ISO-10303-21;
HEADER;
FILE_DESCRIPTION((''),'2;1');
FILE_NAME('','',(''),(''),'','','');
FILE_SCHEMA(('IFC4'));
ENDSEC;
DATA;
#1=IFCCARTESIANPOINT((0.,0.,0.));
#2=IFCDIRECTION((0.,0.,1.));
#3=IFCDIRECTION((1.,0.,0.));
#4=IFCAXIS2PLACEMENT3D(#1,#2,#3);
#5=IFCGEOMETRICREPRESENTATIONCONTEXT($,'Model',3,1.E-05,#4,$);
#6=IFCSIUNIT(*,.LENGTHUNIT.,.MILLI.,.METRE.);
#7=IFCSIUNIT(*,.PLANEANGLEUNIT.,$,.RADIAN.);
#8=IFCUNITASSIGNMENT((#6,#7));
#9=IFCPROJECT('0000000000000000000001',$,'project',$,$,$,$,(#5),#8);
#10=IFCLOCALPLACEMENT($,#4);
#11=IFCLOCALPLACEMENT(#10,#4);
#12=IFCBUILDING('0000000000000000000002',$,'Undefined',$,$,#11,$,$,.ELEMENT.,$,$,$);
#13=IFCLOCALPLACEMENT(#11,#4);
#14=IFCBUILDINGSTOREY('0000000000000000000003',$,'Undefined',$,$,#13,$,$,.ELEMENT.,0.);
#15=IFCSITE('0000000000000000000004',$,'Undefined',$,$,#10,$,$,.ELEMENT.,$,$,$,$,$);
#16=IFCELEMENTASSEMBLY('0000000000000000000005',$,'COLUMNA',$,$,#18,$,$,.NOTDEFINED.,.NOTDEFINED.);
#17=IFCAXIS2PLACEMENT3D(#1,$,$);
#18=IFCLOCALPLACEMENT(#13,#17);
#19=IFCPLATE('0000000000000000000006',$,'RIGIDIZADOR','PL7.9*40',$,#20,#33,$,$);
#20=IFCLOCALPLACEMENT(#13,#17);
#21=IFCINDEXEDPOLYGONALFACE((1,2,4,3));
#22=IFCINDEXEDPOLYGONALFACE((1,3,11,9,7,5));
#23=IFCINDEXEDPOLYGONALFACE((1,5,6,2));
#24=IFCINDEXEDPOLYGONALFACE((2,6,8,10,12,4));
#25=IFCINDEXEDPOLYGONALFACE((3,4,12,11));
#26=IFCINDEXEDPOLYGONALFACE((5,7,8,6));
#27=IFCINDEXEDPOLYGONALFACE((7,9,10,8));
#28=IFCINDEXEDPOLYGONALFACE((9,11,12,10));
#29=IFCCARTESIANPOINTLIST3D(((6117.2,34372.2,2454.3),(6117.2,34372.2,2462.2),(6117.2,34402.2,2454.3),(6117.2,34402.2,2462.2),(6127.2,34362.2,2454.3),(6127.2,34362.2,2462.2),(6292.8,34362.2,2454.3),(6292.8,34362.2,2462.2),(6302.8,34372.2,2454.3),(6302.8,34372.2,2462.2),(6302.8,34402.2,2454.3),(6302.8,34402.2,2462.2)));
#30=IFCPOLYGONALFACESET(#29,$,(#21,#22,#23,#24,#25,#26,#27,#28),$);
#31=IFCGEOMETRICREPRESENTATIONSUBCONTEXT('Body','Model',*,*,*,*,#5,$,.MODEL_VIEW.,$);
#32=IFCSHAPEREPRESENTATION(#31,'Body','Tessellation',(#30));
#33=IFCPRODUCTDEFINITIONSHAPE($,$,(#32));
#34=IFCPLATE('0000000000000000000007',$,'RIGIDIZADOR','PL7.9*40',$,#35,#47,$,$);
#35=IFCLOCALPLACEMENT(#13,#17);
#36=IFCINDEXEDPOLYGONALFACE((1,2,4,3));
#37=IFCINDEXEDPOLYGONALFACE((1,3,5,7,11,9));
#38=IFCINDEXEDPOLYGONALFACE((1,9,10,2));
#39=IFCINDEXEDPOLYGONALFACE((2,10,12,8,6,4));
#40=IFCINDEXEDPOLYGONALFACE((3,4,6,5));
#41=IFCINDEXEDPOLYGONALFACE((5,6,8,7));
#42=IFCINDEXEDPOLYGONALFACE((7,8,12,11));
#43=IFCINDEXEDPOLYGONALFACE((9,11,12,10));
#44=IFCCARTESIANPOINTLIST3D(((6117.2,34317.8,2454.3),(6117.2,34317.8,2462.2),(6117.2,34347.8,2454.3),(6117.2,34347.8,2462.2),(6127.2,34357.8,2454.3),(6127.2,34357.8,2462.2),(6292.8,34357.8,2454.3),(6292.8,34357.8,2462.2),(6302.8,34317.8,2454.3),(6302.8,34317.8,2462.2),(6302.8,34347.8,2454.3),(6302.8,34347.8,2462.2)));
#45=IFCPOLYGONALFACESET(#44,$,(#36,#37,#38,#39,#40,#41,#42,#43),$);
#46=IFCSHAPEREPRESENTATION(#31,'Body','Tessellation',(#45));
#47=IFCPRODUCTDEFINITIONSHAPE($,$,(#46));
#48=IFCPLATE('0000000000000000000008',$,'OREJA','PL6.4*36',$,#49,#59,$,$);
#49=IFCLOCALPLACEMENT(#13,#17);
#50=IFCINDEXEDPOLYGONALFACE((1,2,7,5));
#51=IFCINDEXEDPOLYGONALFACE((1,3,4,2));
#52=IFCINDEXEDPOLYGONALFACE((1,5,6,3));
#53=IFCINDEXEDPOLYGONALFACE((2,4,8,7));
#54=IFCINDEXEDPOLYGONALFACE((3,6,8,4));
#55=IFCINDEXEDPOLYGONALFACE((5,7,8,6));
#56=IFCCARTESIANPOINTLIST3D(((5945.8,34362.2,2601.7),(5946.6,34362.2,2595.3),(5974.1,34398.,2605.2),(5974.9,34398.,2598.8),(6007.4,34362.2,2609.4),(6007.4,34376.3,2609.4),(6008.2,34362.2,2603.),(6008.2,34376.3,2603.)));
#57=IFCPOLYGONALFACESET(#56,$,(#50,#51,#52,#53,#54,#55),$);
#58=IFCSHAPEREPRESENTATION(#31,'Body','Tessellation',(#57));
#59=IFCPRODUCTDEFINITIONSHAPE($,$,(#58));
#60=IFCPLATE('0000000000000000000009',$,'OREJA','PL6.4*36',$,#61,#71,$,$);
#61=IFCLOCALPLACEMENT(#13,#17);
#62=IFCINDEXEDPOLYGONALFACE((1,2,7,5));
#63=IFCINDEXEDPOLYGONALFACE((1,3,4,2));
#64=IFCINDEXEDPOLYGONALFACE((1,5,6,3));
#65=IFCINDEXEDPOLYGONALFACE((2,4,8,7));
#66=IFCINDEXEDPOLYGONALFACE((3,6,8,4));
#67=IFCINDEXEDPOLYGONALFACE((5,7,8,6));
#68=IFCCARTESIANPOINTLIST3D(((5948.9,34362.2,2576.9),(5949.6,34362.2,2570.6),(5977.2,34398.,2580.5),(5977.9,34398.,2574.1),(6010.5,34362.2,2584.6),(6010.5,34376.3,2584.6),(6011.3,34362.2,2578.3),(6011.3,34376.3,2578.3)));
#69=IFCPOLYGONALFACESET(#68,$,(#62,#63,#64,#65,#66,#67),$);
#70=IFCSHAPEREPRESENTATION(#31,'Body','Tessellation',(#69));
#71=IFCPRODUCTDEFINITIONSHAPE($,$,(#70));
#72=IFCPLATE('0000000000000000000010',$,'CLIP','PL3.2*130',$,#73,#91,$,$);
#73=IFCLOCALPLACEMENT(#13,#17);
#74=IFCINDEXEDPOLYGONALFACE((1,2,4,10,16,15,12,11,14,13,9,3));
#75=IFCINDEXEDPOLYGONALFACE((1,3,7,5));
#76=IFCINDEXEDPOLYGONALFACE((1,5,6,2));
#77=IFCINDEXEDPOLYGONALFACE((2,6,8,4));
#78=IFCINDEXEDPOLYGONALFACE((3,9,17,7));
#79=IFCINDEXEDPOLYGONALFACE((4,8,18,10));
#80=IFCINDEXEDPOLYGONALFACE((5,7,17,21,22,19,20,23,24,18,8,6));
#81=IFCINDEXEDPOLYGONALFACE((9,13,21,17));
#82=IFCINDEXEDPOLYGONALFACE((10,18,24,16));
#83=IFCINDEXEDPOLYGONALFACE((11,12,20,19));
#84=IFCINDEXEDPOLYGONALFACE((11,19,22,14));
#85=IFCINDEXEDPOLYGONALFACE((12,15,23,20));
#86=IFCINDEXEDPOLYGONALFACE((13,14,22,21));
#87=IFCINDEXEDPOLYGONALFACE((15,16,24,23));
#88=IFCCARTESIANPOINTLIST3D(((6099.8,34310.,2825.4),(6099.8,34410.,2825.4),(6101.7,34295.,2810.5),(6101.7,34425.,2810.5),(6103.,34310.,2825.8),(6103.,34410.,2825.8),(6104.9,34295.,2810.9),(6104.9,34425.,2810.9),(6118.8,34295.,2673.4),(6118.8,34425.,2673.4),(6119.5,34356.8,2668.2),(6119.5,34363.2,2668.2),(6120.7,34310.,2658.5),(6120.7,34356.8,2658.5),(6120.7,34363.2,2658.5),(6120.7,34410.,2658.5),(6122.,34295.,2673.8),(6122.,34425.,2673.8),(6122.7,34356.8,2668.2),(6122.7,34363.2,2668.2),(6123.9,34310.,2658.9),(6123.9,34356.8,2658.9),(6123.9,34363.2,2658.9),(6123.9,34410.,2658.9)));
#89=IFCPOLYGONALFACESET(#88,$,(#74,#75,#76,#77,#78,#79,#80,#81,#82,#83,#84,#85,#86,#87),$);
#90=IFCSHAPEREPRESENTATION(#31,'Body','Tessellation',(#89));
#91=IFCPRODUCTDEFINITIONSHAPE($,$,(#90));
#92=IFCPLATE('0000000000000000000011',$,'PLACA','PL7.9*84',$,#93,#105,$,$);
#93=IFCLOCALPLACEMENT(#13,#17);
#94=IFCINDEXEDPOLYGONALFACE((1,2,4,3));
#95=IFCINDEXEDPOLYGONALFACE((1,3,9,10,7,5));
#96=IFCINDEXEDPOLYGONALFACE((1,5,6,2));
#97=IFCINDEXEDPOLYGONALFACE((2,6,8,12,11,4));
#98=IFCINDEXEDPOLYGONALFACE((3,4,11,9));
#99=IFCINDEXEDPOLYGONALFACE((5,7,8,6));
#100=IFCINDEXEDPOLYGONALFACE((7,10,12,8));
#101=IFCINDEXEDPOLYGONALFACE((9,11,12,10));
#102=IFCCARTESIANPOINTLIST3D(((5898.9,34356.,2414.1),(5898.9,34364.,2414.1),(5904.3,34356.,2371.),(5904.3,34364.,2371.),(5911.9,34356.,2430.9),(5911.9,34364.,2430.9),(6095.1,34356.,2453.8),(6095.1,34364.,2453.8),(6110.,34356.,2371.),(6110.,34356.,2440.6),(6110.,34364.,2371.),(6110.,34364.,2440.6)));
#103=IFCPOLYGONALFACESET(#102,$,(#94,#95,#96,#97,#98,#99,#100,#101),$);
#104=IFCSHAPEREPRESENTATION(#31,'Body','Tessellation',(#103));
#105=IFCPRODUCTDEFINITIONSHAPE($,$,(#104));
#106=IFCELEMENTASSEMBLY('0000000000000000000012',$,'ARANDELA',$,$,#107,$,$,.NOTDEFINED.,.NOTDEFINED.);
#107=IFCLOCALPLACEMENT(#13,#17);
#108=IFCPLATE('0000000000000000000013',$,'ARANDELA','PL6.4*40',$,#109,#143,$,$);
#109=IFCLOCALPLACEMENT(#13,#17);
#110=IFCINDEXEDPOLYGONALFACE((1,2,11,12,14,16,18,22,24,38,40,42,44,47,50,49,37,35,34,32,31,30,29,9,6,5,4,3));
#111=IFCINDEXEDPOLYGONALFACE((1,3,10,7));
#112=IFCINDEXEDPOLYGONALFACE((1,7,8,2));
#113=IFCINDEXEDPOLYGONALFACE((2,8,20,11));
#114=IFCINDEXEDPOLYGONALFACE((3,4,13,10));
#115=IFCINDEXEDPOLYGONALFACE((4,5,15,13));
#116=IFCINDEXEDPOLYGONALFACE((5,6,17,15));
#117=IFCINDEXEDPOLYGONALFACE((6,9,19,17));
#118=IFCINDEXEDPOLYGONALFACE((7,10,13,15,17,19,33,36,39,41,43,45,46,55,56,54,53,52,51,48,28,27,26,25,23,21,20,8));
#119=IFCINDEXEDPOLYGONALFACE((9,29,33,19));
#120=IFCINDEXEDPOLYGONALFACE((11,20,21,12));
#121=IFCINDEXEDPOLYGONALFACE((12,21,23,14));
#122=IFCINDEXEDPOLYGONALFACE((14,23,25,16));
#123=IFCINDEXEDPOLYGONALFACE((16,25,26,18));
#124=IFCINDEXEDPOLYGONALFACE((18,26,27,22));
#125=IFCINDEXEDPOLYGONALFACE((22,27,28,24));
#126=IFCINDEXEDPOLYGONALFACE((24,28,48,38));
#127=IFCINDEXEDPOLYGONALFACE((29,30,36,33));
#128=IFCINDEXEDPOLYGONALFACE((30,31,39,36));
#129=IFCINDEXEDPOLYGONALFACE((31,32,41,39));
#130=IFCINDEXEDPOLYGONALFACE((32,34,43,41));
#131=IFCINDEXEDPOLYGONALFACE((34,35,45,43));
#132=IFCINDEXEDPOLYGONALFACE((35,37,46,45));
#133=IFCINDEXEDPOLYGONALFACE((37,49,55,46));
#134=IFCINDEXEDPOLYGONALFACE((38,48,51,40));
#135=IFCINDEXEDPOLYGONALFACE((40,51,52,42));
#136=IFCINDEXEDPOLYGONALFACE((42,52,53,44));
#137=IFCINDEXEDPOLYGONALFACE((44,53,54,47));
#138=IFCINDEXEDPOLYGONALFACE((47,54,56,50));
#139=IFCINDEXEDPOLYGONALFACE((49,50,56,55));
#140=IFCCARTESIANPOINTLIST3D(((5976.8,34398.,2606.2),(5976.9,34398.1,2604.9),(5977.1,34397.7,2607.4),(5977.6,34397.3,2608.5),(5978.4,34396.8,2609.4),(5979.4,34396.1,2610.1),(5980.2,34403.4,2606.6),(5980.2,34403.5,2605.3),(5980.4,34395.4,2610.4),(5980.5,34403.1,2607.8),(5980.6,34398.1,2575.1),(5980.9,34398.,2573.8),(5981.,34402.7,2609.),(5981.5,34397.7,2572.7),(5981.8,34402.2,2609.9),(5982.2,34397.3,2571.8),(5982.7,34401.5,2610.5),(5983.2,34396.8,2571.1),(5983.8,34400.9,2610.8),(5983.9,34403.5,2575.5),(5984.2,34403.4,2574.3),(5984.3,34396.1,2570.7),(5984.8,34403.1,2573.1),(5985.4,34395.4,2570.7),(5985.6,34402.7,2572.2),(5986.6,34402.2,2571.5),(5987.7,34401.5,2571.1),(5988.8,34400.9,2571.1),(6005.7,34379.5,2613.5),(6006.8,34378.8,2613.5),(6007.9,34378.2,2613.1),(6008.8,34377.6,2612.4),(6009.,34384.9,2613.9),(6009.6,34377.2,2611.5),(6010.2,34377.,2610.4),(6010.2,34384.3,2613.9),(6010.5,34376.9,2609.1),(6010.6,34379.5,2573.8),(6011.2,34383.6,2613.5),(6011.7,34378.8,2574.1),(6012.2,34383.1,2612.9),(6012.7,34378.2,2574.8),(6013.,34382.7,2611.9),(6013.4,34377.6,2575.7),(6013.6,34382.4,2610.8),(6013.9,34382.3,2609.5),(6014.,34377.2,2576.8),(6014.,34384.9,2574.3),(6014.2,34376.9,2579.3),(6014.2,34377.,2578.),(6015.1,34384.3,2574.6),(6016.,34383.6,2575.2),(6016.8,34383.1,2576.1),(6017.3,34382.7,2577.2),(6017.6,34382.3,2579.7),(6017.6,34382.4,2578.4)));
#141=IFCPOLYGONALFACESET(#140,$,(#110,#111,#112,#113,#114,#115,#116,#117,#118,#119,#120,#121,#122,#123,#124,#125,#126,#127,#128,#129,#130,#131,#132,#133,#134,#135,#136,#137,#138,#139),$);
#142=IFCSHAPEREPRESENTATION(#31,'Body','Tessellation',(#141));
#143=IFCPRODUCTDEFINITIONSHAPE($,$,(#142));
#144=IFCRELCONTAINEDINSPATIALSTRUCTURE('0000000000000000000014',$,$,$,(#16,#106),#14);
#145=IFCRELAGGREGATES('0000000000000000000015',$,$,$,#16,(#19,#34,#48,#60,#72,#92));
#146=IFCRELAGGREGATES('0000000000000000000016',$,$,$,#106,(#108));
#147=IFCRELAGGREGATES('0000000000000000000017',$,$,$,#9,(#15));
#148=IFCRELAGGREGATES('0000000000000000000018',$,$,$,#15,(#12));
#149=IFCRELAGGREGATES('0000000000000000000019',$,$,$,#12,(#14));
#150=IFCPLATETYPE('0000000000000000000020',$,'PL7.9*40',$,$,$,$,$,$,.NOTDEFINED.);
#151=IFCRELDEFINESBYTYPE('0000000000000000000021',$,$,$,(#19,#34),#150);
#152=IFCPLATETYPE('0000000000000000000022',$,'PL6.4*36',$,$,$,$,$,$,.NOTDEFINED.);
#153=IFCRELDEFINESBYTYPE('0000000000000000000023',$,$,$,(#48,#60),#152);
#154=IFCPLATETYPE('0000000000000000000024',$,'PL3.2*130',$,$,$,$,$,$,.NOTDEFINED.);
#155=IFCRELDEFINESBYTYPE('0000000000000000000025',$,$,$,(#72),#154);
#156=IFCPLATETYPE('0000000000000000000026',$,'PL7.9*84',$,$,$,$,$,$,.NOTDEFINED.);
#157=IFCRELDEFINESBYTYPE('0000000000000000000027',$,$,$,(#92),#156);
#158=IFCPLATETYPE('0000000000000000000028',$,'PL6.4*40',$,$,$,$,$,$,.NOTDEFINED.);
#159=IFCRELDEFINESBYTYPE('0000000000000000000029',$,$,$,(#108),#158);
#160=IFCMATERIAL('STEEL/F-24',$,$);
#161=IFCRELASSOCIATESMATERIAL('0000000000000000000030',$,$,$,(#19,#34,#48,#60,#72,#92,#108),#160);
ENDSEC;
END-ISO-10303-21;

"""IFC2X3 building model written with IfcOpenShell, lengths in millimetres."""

from ifc_helpers import new_model, si_unit, frame, frame_2d, origin_with_axes, place, context, subcontext, project, spatial, polyline, circle_curve, parameter, trimmed, segment, composite_curve, outline, extrude, boolean, material, type_object, element, aggregate, save


model = new_model("IFC2X3")

# Units and contexts
model_context = context("Model", 3, precision=1e-05, world=origin_with_axes())
body_context = subcontext(model_context, "Body", "Model", "MODEL_VIEW")
ifc_project = project(units=[si_unit("LENGTHUNIT", "METRE", prefix="MILLI"), si_unit("PLANEANGLEUNIT", "RADIAN")], contexts=[model_context])

# Site, building, storey
site_placement = place(None, origin_with_axes())
site = spatial("IfcSite", under=ifc_project, at=site_placement, Name="Undefined", CompositionType="ELEMENT")
building_placement = place(site_placement, origin_with_axes())
building = spatial("IfcBuilding", under=site, at=building_placement, Name="Undefined", CompositionType="ELEMENT")
storey_placement = place(building_placement, origin_with_axes())
storey = spatial("IfcBuildingStorey", under=building, at=storey_placement, Name="Undefined", CompositionType="ELEMENT", Elevation=0.0)

# Element assembly
ifc_material_1 = material(Name="STEEL/F-24")
assembly_1_placement = place(storey_placement, origin_with_axes())
assembly_1 = element("IfcElementAssembly", 1, at=assembly_1_placement, inside=storey, Name="COLUMNA", AssemblyPlace="NOTDEFINED", PredefinedType="NOTDEFINED")

# Plates
plate_type_1 = type_object("IfcPlateType", Name="PL7.9*40", PredefinedType="NOTDEFINED")
plate_1_placement = place(assembly_1_placement, frame((6117.2, 34402.2, 2458.3), z_axis=(0.0, 0.0, 1.0), x_axis=(0.0, -1.0, 0.0)))
plate_1 = element("IfcPlate", 2, at=plate_1_placement, type_object=plate_type_1, material=ifc_material_1, Name="RIGIDIZADOR", Description="PL7.9*40", context=body_context, shape_type="SweptSolid", body=[
    extrude(outline(polyline([(0.0, 0.0), (30.0, 0.0), (40.0, 10.0), (40.0, 175.6), (30.0, 185.6), (0.0, 185.6), (0.0, 0.0)])), frame((0.0, 0.0, -4.0), z_axis=(0.0, 0.0, 1.0), x_axis=(1.0, 0.0, 0.0)), (0.0, 0.0, 1.0), 7.9),
])
plate_2_placement = place(assembly_1_placement, frame((6117.2, 34357.8, 2458.3), z_axis=(0.0, 0.0, 1.0), x_axis=(0.0, -1.0, 0.0)))
plate_2 = element("IfcPlate", 3, at=plate_2_placement, type_object=plate_type_1, material=ifc_material_1, Name="RIGIDIZADOR", Description="PL7.9*40", context=body_context, shape_type="SweptSolid", body=[
    extrude(outline(polyline([(0.0, 10.0), (10.0, 0.0), (40.0, 0.0), (40.0, 185.6), (10.0, 185.6), (0.0, 175.6), (0.0, 10.0)])), frame((0.0, 0.0, -4.0), z_axis=(0.0, 0.0, 1.0), x_axis=(1.0, 0.0, 0.0)), (0.0, 0.0, 1.0), 7.9),
])
plate_type_2 = type_object("IfcPlateType", Name="PL6.4*36", PredefinedType="NOTDEFINED")
plate_3_placement = place(assembly_1_placement, frame((6007.8, 34362.2, 2606.2), z_axis=(0.124075, 0.0, -0.992273), x_axis=(-0.992273, 0.0, -0.124075)))
plate_3 = element("IfcPlate", 4, at=plate_3_placement, type_object=plate_type_2, material=ifc_material_1, Name="OREJA", Description="PL6.4*36", context=body_context, shape_type="SweptSolid", body=[
    extrude(outline(polyline([(0.0, 0.0), (62.1, 0.0), (33.6, 35.8), (0.0, 14.0), (0.0, 0.0)])), frame((0.0, 0.0, -3.2), z_axis=(0.0, 0.0, 1.0), x_axis=(1.0, 0.0, 0.0)), (0.0, 0.0, 1.0), 6.4),
])
plate_4_placement = place(assembly_1_placement, frame((6010.9, 34362.2, 2581.5), z_axis=(0.124075, 0.0, -0.992273), x_axis=(-0.992273, 0.0, -0.124075)))
plate_4 = element("IfcPlate", 5, at=plate_4_placement, type_object=plate_type_2, material=ifc_material_1, Name="OREJA", Description="PL6.4*36", context=body_context, shape_type="SweptSolid", body=[
    extrude(outline(polyline([(0.0, 0.0), (62.1, 0.0), (33.6, 35.8), (0.0, 14.0), (0.0, 0.0)])), frame((0.0, 0.0, -3.2), z_axis=(0.0, 0.0, 1.0), x_axis=(1.0, 0.0, 0.0)), (0.0, 0.0, 1.0), 6.4),
])
plate_type_3 = type_object("IfcPlateType", Name="PL3.2*130", PredefinedType="NOTDEFINED")
plate_5_placement = place(assembly_1_placement, frame((6101.4, 34295.0, 2825.6), z_axis=(-0.992271, 0.0, -0.124089), x_axis=(0.0, 1.0, 0.0)))
plate_5 = element("IfcPlate", 6, at=plate_5_placement, type_object=plate_type_3, material=ifc_material_1, Name="CLIP", Description="PL3.2*130", context=body_context, shape_type="CSG", body=[
    boolean("DIFFERENCE", extrude(outline(polyline([(0.0, 15.0), (15.0, 0.0), (115.0, 0.0), (130.0, 15.0), (130.0, 153.1), (115.0, 168.1), (15.0, 168.1), (0.0, 153.1), (0.0, 15.0)])), frame((0.0, 0.0, -1.6), z_axis=(0.0, 0.0, 1.0), x_axis=(1.0, 0.0, 0.0)), (0.0, 0.0, 1.0), 3.2), extrude(outline(polyline([(0.0, 0.0), (9.7, 0.0), (9.7, 6.3), (0.0, 6.3), (0.0, 0.0)])), frame((68.2, 165.2, 25.3), z_axis=(0.0, 0.124089, -0.992271), x_axis=(0.0, -0.992271, -0.124089)), (0.0, 0.0, 1.0), 30.0)),
])
plate_type_4 = type_object("IfcPlateType", Name="PL7.9*84", PredefinedType="NOTDEFINED")
plate_6_placement = place(assembly_1_placement, frame((5904.3, 34360.0, 2371.0), z_axis=(0.0, -1.0, 0.0), x_axis=(1.0, 0.0, 0.0)))
plate_6 = element("IfcPlate", 7, at=plate_6_placement, type_object=plate_type_4, material=ifc_material_1, Name="PLACA", Description="PL7.9*84", context=body_context, shape_type="SweptSolid", body=[
    extrude(outline(polyline([(0.0, 0.0), (205.7, 0.0), (205.7, 69.6), (190.9, 82.7), (7.6, 59.8), (-5.4, 43.1), (0.0, 0.0)])), frame((0.0, 0.0, -4.0), z_axis=(0.0, 0.0, 1.0), x_axis=(1.0, 0.0, 0.0)), (0.0, 0.0, 1.0), 7.9),
])

# Element assembly, plate
assembly_2_placement = place(storey_placement, origin_with_axes())
assembly_2 = element("IfcElementAssembly", 8, at=assembly_2_placement, inside=storey, Name="ARANDELA", AssemblyPlace="NOTDEFINED", PredefinedType="NOTDEFINED")
plate_type_5 = type_object("IfcPlateType", Name="PL6.4*40", PredefinedType="NOTDEFINED")
plate_7_placement = place(assembly_2_placement, frame((5977.9, 34400.8, 2610.0), z_axis=(0.526076, 0.84789, 0.065781), x_axis=(0.841338, -0.530172, 0.105202)))
plate_7 = element("IfcPlate", 9, at=plate_7_placement, type_object=plate_type_5, material=ifc_material_1, Name="ARANDELA", Description="PL6.4*40", context=body_context, shape_type="SweptSolid", body=[
    extrude(outline(composite_curve([segment(trimmed(circle_curve(frame_2d((5.0, 5.0), x_axis=(-1.0, 0.0)), 5.0), [parameter(0.0)], [parameter(1.570796)], True, "PARAMETER"), True, "CONTINUOUS"), segment(polyline([(5.0, 0.0), (35.0, 0.0)]), True, "CONTINUOUS"), segment(trimmed(circle_curve(frame_2d((35.0, 5.0), x_axis=(0.0, -1.0)), 5.0), [parameter(0.0)], [parameter(1.570796)], True, "PARAMETER"), True, "CONTINUOUS"), segment(polyline([(40.0, 5.0), (40.0, 35.0)]), True, "CONTINUOUS"), segment(trimmed(circle_curve(frame_2d((35.0, 35.0), x_axis=(1.0, 0.0)), 5.0), [parameter(0.0)], [parameter(1.570796)], True, "PARAMETER"), True, "CONTINUOUS"), segment(polyline([(35.0, 40.0), (5.0, 40.0)]), True, "CONTINUOUS"), segment(trimmed(circle_curve(frame_2d((5.0, 35.0), x_axis=(0.0, 1.0)), 5.0), [parameter(0.0)], [parameter(1.570796)], True, "PARAMETER"), True, "CONTINUOUS"), segment(polyline([(0.0, 35.0), (0.0, 5.0)]), True, "CONTINUOUS")], self_intersect=True)), frame((0.0, 0.0, -3.2), z_axis=(0.0, 0.0, 1.0), x_axis=(1.0, 0.0, 0.0)), (0.0, 0.0, 1.0), 6.4),
])

aggregate(assembly_1, [plate_1, plate_2, plate_3, plate_4, plate_5, plate_6])

aggregate(assembly_2, [plate_7])

save(model, "model.ifc")
